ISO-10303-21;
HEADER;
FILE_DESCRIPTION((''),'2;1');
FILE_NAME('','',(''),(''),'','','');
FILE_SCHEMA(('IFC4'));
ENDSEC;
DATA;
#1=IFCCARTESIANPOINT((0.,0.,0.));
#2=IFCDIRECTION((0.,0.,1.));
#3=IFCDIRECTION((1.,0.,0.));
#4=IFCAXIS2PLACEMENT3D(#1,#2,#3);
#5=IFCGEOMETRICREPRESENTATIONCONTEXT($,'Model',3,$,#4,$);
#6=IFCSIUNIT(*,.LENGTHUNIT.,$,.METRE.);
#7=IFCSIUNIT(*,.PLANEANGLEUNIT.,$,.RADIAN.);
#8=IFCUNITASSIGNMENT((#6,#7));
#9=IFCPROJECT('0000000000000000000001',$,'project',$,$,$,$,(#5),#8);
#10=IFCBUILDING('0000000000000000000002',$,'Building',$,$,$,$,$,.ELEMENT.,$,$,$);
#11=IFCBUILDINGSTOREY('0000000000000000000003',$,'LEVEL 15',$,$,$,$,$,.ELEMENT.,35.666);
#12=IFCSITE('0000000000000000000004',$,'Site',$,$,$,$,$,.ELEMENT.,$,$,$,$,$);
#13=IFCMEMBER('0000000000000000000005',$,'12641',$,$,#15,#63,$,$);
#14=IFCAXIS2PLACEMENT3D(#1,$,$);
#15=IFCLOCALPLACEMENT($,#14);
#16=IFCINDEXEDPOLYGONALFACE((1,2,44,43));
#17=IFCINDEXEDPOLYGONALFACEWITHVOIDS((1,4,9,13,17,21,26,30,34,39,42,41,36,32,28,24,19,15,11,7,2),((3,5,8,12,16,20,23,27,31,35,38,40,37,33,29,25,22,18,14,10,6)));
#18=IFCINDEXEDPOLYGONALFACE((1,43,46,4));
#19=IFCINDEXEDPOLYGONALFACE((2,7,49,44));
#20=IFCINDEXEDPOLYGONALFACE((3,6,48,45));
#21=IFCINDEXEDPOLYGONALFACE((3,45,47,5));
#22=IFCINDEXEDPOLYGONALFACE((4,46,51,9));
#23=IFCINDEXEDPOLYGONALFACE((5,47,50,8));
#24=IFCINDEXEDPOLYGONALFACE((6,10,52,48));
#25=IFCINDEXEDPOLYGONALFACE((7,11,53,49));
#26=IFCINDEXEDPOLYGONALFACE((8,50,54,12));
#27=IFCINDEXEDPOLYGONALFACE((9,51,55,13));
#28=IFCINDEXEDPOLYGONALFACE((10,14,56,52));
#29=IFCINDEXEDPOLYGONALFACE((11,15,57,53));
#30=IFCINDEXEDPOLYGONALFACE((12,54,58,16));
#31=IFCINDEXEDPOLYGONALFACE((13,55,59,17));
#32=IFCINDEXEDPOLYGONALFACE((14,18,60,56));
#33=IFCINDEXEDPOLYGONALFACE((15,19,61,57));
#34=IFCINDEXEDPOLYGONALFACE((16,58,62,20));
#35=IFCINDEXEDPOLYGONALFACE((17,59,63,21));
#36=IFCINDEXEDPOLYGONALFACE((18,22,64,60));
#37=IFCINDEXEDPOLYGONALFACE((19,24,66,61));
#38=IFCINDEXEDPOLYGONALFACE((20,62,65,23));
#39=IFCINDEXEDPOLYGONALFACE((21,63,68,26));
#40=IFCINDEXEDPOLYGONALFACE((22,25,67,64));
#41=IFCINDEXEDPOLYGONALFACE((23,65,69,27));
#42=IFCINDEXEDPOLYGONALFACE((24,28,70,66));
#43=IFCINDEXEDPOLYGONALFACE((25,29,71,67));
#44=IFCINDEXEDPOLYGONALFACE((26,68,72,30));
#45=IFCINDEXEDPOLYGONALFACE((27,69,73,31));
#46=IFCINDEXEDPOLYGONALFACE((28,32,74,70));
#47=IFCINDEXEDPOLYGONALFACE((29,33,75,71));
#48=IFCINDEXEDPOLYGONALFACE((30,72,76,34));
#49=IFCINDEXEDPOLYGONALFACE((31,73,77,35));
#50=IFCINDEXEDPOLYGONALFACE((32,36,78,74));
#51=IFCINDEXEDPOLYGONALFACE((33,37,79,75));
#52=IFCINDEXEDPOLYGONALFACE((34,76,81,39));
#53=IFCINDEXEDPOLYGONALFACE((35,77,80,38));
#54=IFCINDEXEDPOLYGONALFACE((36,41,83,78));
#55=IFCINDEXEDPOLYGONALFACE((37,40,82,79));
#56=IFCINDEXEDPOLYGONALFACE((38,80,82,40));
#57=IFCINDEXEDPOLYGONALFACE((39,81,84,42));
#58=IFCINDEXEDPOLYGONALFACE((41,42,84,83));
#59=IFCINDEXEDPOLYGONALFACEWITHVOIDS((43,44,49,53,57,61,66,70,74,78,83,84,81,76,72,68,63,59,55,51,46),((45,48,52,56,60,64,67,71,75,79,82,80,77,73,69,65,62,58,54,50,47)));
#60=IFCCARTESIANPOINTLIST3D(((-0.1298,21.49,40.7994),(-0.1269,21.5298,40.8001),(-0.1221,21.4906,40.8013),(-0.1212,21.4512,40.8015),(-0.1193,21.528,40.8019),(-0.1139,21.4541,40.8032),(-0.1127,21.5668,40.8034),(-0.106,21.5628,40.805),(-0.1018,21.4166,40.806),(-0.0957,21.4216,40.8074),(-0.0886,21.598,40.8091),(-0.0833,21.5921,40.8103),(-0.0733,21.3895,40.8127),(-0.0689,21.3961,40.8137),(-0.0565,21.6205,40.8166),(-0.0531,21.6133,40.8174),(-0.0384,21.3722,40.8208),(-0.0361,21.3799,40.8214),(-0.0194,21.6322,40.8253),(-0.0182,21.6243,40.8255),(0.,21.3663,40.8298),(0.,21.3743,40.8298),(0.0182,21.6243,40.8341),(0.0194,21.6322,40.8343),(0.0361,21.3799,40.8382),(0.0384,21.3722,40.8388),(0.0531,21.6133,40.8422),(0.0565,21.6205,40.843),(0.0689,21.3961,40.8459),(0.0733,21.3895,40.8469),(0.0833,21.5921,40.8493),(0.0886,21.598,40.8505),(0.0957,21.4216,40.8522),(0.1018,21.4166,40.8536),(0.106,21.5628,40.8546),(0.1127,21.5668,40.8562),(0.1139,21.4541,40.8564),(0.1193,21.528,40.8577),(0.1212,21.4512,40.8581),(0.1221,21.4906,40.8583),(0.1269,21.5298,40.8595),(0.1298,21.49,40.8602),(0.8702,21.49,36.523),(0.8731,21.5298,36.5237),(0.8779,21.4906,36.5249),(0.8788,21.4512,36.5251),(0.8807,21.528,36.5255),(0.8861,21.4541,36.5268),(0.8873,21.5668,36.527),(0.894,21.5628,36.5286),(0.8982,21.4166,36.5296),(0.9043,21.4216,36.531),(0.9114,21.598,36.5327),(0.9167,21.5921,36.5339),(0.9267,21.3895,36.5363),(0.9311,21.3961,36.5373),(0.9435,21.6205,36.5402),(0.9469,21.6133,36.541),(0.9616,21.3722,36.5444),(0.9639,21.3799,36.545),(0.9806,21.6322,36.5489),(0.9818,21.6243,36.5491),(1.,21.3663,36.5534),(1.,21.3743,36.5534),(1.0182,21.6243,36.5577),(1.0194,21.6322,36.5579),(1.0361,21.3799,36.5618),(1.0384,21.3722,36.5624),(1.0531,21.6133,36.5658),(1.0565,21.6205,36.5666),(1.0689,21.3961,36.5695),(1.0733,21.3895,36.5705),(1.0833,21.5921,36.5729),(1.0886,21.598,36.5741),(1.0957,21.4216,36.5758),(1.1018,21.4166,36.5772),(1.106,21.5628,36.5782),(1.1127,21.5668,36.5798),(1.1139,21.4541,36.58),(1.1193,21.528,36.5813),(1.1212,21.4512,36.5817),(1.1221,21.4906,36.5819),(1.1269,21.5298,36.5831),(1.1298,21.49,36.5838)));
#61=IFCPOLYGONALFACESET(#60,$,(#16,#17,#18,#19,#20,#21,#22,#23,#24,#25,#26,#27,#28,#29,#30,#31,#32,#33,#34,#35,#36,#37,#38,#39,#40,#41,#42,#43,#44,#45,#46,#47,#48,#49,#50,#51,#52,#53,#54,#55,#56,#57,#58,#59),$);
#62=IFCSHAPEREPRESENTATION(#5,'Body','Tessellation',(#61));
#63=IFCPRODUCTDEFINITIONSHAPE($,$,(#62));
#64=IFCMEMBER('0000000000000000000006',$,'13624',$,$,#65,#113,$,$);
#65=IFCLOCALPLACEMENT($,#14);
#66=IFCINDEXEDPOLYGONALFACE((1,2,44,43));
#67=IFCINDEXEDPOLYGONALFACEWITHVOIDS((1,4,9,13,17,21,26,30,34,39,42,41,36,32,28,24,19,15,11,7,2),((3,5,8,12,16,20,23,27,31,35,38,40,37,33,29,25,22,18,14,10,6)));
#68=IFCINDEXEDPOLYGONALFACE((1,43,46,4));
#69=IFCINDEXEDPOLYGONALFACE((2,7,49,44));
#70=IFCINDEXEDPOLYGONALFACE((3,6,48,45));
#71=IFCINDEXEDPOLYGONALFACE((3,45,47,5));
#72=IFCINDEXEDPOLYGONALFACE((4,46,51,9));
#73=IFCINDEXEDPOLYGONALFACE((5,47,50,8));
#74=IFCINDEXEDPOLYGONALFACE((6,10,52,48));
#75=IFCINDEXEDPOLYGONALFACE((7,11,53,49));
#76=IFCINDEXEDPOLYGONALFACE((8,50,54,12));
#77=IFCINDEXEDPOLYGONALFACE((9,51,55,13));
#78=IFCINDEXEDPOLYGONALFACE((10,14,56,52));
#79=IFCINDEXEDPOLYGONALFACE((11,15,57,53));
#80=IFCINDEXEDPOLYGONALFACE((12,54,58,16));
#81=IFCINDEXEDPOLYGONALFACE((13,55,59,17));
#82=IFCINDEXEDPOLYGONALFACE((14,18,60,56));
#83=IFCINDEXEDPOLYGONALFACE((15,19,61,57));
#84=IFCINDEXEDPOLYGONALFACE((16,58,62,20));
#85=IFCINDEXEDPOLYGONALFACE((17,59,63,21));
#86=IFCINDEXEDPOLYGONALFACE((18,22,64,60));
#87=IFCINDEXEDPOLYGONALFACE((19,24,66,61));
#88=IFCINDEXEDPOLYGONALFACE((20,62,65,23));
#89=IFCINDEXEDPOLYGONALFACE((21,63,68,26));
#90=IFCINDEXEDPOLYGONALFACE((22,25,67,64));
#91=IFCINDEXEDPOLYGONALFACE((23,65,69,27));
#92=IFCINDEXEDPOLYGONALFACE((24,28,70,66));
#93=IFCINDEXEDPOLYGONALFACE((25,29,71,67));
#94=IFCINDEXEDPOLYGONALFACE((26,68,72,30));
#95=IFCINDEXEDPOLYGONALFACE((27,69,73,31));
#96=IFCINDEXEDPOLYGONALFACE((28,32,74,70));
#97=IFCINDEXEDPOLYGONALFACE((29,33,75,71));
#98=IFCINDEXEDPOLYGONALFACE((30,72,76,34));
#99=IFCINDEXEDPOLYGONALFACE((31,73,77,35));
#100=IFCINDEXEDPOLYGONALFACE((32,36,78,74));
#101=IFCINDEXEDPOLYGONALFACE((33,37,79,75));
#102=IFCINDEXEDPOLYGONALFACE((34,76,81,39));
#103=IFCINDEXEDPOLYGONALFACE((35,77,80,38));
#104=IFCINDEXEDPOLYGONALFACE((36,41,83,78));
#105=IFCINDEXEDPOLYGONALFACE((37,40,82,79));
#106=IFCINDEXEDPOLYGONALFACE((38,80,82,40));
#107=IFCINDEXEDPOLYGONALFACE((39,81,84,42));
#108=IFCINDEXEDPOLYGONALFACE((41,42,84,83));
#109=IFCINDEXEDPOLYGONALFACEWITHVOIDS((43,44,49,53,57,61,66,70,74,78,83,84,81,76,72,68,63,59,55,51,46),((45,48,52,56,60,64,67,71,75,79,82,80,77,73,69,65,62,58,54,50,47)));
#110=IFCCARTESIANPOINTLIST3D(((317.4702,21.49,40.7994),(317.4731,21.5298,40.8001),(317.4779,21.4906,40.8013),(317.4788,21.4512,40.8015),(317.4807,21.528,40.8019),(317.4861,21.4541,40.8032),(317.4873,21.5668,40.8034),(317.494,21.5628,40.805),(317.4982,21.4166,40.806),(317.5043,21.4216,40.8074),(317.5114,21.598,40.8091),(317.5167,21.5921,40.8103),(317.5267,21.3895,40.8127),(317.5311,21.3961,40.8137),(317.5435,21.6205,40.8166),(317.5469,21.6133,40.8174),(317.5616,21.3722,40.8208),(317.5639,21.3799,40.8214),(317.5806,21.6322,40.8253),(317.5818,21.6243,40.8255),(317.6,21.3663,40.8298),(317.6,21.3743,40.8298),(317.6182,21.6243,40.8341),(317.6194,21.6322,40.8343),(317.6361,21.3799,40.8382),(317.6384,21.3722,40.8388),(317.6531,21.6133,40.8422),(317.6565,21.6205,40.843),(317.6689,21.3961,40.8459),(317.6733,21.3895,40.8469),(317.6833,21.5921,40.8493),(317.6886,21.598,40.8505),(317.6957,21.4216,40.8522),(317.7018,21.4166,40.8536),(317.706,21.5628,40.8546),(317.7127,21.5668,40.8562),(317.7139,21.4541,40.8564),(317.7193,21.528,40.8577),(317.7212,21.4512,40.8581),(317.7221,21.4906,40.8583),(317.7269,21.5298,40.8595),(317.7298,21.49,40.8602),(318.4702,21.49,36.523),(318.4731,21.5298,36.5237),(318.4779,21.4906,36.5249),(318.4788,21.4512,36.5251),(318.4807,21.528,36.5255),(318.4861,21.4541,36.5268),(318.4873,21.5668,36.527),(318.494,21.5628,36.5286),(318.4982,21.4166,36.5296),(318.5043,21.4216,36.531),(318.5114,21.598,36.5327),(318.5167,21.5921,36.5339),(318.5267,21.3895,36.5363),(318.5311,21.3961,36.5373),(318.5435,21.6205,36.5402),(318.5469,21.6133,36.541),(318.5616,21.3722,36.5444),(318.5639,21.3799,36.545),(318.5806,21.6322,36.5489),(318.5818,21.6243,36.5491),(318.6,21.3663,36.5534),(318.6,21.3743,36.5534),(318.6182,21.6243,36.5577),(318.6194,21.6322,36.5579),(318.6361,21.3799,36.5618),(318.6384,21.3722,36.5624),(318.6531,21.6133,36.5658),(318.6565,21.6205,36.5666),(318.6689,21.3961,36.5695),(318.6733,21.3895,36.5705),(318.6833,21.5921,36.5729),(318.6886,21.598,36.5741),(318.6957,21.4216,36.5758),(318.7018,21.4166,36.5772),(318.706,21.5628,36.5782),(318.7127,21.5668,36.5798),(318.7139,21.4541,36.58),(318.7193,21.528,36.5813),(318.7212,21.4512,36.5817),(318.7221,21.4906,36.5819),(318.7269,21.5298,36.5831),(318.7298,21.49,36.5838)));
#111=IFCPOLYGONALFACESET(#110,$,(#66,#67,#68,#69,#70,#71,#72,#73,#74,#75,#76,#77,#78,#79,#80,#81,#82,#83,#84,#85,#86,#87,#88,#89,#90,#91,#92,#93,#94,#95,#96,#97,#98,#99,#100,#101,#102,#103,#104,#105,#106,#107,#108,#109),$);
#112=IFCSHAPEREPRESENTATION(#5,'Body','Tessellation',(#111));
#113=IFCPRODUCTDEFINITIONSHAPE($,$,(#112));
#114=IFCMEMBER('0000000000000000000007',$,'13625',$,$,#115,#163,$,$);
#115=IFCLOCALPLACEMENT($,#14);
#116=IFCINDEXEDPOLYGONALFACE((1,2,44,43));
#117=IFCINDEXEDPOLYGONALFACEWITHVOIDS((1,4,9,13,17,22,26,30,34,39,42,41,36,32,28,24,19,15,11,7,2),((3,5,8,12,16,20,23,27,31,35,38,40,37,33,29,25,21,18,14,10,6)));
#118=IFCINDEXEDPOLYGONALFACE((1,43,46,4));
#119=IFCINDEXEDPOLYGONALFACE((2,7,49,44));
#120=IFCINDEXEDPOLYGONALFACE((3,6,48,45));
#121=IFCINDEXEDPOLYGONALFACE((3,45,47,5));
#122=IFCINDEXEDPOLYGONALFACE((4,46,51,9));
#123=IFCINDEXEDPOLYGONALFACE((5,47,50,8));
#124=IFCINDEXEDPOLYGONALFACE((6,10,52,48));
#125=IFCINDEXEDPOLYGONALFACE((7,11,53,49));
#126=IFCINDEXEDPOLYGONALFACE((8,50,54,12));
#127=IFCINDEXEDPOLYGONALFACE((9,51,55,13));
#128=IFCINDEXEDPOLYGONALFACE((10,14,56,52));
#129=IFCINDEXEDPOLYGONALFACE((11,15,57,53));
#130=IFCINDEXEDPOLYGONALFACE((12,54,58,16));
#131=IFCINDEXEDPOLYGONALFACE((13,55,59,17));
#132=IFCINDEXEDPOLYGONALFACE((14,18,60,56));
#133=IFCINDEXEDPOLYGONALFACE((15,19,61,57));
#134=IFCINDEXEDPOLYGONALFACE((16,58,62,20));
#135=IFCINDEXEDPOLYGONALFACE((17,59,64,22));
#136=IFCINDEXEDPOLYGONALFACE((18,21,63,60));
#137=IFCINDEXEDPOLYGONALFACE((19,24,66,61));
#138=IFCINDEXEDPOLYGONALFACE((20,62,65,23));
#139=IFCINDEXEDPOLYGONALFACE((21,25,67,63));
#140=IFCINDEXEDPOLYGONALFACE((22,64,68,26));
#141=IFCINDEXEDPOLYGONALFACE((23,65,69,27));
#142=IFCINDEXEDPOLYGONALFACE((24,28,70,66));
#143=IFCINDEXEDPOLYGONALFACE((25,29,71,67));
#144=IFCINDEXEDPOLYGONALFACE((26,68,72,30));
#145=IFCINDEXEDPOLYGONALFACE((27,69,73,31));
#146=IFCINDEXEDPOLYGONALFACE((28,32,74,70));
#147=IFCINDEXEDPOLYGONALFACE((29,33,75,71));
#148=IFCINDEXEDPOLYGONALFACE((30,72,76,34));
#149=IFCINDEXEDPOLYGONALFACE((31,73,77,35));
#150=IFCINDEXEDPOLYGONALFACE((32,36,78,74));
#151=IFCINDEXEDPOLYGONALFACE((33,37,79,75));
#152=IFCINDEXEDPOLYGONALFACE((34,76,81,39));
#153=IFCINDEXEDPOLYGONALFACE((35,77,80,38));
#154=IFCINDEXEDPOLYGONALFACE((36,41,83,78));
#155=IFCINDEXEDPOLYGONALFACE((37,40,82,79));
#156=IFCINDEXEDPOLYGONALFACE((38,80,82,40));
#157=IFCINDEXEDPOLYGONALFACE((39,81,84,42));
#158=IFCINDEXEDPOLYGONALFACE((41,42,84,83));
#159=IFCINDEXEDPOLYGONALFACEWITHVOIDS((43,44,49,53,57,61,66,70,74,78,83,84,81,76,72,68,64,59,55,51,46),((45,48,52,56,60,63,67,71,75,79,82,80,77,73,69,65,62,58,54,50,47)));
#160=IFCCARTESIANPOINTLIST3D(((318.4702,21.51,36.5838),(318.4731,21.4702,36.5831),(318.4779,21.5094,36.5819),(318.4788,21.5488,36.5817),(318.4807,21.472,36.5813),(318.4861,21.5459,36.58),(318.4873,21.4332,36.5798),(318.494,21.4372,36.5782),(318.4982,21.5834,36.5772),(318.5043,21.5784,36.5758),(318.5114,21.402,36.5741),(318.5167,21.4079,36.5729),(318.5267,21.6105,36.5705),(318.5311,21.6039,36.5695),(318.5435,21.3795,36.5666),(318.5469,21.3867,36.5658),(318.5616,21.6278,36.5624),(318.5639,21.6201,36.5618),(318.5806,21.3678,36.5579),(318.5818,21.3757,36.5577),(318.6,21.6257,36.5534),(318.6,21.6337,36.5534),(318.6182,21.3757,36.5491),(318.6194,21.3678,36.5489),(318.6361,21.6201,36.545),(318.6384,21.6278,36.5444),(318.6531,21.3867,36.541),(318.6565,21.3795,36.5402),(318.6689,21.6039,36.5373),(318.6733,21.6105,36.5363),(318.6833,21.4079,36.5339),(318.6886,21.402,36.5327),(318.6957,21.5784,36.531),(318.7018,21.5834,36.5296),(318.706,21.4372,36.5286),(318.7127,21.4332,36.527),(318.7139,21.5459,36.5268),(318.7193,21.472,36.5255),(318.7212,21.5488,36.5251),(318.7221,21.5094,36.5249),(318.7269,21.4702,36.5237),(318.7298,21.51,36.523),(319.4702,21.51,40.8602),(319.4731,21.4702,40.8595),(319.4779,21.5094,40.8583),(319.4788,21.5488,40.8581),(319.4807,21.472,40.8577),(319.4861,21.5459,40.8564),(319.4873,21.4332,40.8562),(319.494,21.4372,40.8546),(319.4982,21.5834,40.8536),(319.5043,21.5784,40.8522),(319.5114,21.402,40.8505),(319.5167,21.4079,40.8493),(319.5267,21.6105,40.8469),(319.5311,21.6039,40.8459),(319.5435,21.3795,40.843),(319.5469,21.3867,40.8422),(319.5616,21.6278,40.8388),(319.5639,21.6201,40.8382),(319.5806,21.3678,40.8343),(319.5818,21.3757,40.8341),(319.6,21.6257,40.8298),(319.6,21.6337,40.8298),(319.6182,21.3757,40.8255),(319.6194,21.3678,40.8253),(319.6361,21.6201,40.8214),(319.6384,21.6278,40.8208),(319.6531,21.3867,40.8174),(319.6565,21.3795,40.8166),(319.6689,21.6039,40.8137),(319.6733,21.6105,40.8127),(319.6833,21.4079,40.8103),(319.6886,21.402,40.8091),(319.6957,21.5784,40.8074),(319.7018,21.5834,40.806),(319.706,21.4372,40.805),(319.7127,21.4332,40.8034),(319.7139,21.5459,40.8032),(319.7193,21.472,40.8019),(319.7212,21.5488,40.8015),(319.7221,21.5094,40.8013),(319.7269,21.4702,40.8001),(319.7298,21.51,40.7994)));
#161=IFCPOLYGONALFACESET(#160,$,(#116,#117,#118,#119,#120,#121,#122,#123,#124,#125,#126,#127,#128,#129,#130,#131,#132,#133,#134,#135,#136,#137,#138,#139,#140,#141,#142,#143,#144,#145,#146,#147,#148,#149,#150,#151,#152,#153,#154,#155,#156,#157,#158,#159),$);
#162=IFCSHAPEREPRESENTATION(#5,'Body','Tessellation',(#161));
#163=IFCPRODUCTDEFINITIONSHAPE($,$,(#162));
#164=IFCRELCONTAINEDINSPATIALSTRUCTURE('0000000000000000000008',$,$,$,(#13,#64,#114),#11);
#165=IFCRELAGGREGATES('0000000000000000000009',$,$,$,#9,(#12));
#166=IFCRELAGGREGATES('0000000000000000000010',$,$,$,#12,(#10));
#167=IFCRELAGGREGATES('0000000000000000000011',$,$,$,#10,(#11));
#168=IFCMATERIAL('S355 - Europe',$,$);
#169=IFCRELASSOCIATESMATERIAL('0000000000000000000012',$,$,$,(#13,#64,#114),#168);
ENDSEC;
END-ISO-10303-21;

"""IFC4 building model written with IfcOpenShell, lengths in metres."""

from ifc_helpers import new_model, si_unit, frame, origin_with_axes, origin_2d_with_axis, place, context, project, spatial, hollow_circle, extrude, material, material_profile, profile_set, profile_usage, element, save


model = new_model("IFC4")

# Units and contexts
model_context = context("Model", 3, world=origin_with_axes())
ifc_project = project(units=[si_unit("LENGTHUNIT", "METRE"), si_unit("PLANEANGLEUNIT", "RADIAN")], contexts=[model_context])

# Site, building, storey
site = spatial("IfcSite", under=ifc_project, Name="Site", CompositionType="ELEMENT")
building = spatial("IfcBuilding", under=site, Name="Building", CompositionType="ELEMENT")
storey = spatial("IfcBuildingStorey", under=building, Name="LEVEL 15", CompositionType="ELEMENT", Elevation=35.666)

# Shared definitions
ifc_material = material(Name="S355 - Europe")

# Members
ifc_material_profile_1 = material_profile(ifc_material, hollow_circle(Radius=0.1337, WallThickness=0.008, at=origin_2d_with_axis()))
ifc_profile_set_1 = profile_set([ifc_material_profile_1])
ifc_profile_usage_1 = profile_usage(ifc_profile_set_1, cardinal=10)
member_1_placement = place(None, frame((1.0, 21.5, 36.5534), z_axis=(-0.227699, 0.0, 0.973732), x_axis=(0.0, -1.0, 0.0)))
element("IfcMember", 1, at=member_1_placement, inside=storey, material=ifc_profile_usage_1, Name="12641", context=model_context, shape_type="SweptSolid", body=[
    extrude(hollow_circle(Radius=0.1337, WallThickness=0.008, at=origin_2d_with_axis()), origin_with_axes(), (0.0, 0.0, 1.0), 4.3918),
])
ifc_material_profile_2 = material_profile(ifc_material, hollow_circle(Radius=0.1337, WallThickness=0.008, at=origin_2d_with_axis()))
ifc_profile_set_2 = profile_set([ifc_material_profile_2])
ifc_profile_usage_2 = profile_usage(ifc_profile_set_2, cardinal=10)
member_2_placement = place(None, frame((318.6, 21.5, 36.5534), z_axis=(-0.227699, 0.0, 0.973732), x_axis=(0.0, -1.0, 0.0)))
element("IfcMember", 2, at=member_2_placement, inside=storey, material=ifc_profile_usage_2, Name="13624", context=model_context, shape_type="SweptSolid", body=[
    extrude(hollow_circle(Radius=0.1337, WallThickness=0.008, at=origin_2d_with_axis()), origin_with_axes(), (0.0, 0.0, 1.0), 4.3918),
])
ifc_material_profile_3 = material_profile(ifc_material, hollow_circle(Radius=0.1337, WallThickness=0.008, at=origin_2d_with_axis()))
ifc_profile_set_3 = profile_set([ifc_material_profile_3])
ifc_profile_usage_3 = profile_usage(ifc_profile_set_3, cardinal=10)
member_3_placement = place(None, frame((318.6, 21.5, 36.5534), z_axis=(0.227699, 0.0, 0.973732), x_axis=(0.0, 1.0, 0.0)))
element("IfcMember", 3, at=member_3_placement, inside=storey, material=ifc_profile_usage_3, Name="13625", context=model_context, shape_type="SweptSolid", body=[
    extrude(hollow_circle(Radius=0.1337, WallThickness=0.008, at=origin_2d_with_axis()), origin_with_axes(), (0.0, 0.0, 1.0), 4.3918),
])

save(model, "model.ifc")
